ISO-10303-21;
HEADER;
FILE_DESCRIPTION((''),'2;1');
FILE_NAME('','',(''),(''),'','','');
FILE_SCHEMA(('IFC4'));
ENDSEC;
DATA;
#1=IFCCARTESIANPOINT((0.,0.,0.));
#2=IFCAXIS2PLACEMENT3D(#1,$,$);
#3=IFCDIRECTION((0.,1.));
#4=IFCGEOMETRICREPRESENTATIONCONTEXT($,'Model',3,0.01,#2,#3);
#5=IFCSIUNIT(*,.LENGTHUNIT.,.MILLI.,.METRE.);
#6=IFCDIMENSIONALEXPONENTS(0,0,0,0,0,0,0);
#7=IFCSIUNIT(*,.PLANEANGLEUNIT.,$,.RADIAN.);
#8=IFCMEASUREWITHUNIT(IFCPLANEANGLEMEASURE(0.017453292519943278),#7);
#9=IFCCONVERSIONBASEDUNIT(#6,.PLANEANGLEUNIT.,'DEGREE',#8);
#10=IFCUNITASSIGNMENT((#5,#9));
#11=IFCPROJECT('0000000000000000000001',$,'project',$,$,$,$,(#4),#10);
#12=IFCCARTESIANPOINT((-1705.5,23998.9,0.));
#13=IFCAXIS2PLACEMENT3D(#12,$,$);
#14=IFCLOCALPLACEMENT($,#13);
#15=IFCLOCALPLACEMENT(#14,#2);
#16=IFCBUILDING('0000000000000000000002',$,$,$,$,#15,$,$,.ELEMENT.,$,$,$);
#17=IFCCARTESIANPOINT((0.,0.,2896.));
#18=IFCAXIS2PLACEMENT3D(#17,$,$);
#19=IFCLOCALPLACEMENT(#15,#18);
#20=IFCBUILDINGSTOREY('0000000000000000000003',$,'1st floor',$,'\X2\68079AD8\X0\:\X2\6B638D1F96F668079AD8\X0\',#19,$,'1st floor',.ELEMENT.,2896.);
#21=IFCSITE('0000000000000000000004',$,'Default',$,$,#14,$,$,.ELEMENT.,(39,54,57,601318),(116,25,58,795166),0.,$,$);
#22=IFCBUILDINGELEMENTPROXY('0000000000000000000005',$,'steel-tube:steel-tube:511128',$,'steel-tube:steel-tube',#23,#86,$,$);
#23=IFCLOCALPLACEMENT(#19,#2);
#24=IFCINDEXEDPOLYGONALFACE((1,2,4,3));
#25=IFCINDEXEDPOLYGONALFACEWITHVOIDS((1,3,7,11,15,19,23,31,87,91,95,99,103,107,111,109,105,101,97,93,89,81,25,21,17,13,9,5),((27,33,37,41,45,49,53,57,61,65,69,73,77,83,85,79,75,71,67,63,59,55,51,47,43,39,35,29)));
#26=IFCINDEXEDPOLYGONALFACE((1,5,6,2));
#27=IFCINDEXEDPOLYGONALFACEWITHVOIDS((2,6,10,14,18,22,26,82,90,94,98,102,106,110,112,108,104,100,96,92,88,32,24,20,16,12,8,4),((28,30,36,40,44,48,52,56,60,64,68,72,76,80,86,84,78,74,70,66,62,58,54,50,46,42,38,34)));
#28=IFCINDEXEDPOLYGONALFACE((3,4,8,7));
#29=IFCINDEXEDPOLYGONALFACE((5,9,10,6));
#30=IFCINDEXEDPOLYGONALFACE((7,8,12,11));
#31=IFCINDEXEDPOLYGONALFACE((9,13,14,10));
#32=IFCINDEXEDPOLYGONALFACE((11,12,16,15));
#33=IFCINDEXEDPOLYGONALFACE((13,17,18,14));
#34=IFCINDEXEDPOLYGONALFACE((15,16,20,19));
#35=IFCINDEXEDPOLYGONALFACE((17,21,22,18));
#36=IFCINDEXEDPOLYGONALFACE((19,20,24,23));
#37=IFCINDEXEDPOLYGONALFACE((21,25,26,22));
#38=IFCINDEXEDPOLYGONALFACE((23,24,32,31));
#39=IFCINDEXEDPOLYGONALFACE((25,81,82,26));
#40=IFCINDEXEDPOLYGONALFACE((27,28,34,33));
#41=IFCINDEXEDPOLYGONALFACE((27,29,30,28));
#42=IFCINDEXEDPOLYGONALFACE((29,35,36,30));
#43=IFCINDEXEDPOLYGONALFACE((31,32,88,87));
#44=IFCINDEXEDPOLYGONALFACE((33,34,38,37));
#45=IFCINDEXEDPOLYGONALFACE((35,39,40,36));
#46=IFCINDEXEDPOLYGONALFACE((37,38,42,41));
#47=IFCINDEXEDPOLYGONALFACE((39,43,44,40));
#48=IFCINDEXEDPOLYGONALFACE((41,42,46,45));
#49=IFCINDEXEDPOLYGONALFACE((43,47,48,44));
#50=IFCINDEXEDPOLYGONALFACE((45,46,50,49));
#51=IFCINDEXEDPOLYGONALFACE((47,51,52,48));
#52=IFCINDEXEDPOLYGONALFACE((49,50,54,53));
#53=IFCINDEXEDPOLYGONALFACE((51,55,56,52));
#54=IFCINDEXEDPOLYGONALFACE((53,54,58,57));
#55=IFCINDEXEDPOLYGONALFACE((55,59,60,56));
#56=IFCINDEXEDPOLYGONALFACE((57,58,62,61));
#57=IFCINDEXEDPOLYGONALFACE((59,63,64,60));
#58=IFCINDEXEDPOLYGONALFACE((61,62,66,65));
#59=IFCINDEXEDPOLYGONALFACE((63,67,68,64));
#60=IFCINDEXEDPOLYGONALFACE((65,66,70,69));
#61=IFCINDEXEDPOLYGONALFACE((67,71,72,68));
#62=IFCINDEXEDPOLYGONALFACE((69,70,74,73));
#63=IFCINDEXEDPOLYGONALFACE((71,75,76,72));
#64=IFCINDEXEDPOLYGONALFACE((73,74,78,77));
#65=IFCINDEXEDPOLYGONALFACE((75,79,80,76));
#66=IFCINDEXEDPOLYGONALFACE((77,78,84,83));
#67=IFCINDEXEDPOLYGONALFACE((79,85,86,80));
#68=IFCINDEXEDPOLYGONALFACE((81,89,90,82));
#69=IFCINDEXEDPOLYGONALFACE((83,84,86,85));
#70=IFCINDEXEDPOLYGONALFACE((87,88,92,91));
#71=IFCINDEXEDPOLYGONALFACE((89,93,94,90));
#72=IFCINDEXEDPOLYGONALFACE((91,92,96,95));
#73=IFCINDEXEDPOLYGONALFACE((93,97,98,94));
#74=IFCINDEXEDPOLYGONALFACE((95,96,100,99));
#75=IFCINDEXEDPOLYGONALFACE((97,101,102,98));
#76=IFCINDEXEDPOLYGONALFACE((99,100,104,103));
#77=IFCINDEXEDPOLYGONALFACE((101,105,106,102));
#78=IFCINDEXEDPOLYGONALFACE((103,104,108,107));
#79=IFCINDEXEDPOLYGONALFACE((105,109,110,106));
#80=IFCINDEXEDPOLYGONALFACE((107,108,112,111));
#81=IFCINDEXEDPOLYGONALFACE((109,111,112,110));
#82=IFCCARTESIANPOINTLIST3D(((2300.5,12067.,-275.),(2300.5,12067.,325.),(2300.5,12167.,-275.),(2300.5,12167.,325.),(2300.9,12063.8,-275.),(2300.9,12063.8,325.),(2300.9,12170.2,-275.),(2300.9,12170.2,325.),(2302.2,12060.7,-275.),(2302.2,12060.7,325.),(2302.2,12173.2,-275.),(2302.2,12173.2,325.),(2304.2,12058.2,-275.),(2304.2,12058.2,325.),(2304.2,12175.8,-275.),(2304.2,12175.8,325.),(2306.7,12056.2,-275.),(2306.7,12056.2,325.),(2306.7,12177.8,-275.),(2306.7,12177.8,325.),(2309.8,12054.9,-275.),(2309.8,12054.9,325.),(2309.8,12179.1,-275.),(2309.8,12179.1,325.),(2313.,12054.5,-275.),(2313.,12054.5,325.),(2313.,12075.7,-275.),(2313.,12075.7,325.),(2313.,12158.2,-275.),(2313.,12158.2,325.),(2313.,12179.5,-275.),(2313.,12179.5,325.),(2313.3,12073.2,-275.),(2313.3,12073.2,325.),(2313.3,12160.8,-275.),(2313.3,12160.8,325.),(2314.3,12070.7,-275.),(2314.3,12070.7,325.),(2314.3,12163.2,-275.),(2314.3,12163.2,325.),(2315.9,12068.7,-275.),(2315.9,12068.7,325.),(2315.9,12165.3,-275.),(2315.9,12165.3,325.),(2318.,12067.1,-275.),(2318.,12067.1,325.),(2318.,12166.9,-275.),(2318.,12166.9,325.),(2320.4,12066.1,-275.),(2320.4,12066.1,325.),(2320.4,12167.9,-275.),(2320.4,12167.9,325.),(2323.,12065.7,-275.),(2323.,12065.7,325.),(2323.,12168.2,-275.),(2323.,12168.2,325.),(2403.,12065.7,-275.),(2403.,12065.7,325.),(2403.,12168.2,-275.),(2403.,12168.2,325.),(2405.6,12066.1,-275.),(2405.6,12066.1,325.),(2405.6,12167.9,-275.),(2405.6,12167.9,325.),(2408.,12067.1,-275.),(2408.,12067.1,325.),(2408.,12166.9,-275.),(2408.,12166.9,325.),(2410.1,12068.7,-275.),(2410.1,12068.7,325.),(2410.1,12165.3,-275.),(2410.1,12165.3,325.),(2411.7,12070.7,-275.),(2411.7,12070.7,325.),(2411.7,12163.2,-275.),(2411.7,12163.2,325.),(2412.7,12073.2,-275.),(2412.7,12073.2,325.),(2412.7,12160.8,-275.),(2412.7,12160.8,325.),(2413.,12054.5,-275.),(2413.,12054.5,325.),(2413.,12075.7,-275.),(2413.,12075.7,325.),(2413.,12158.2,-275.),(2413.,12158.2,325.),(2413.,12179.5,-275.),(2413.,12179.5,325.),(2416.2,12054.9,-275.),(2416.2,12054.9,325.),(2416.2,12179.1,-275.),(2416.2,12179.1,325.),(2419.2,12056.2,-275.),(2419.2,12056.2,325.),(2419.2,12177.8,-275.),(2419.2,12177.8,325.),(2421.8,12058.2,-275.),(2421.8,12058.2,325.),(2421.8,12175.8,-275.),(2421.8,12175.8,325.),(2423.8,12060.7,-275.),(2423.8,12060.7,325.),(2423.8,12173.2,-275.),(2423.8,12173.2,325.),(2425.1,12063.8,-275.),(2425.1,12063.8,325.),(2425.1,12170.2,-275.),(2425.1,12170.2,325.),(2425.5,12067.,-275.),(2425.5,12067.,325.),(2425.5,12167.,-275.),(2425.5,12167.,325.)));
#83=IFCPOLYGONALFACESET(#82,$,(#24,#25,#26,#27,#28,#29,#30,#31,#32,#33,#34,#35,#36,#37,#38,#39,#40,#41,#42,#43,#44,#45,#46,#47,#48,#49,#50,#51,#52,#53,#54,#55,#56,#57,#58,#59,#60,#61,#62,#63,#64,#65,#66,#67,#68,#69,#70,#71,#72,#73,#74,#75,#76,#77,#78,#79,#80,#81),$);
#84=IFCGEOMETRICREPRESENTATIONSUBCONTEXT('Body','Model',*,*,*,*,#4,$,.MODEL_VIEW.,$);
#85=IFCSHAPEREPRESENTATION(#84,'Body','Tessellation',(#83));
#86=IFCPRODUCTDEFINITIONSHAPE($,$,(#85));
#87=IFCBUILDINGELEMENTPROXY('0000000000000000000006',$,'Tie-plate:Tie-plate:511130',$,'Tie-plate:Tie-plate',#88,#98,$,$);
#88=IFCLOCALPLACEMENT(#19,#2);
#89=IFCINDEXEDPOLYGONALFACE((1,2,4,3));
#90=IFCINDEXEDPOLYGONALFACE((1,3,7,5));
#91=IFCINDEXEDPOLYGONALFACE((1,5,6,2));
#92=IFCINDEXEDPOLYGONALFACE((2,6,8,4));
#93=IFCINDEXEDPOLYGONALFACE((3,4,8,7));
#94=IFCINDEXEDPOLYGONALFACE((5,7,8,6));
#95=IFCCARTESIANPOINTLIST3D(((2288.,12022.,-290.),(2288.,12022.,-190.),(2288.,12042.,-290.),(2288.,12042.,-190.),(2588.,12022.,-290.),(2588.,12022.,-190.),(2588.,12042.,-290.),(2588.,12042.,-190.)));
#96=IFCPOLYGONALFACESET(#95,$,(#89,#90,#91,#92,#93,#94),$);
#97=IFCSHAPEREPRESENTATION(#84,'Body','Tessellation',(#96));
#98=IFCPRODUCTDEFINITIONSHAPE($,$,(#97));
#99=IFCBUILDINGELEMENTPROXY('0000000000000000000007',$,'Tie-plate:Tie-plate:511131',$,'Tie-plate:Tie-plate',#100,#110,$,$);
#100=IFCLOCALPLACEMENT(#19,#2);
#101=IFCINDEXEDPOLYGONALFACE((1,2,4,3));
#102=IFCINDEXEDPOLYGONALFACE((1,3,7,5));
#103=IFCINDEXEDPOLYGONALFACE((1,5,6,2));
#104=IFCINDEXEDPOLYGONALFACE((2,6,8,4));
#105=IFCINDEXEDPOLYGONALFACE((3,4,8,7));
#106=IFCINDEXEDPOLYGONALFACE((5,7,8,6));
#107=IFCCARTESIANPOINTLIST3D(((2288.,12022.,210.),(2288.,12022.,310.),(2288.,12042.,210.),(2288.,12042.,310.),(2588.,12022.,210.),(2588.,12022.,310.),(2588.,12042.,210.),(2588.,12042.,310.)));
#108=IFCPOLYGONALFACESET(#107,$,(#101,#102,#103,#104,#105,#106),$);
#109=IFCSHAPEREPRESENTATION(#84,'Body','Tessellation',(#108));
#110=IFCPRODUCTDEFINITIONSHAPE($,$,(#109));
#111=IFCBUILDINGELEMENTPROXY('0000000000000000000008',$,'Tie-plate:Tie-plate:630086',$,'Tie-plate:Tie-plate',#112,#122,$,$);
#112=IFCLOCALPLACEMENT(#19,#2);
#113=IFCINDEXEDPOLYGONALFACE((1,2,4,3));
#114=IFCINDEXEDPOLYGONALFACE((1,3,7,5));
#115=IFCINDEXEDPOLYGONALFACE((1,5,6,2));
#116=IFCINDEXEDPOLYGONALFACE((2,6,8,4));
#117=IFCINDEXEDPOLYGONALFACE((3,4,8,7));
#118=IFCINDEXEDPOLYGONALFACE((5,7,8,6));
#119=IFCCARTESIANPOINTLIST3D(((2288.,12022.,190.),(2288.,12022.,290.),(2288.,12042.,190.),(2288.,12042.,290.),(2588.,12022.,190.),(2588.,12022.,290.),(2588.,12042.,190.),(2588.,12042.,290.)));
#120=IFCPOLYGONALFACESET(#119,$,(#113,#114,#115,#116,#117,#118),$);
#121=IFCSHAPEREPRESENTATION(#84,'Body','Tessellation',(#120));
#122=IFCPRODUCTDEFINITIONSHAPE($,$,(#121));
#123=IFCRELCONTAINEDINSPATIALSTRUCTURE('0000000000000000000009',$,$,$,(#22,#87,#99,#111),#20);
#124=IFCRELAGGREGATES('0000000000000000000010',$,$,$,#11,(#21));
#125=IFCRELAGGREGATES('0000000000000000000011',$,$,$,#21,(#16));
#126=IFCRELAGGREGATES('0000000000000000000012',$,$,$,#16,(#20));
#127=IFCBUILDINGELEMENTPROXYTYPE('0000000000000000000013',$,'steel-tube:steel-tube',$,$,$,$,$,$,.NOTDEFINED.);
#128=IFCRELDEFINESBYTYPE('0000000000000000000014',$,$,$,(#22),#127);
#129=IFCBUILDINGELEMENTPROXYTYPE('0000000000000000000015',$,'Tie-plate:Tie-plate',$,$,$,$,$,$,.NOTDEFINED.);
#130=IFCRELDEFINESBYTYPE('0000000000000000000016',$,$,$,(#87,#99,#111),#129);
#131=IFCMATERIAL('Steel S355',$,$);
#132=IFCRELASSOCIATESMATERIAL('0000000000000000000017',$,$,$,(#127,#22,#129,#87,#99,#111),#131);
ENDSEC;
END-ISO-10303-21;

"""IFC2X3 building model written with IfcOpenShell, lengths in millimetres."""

from ifc_helpers import new_model, entity, si_unit, converted_unit, direction, frame, frame_2d, origin, place, context, subcontext, project, spatial, polyline, circle_curve, parameter, trimmed, segment, composite_curve, rectangle, outline, extrude, source, transform, mapped, material, type_object, type_shapes, element, save


model = new_model("IFC2X3")

# Units and contexts
model_context = context("Model", 3, precision=0.01, world=origin(), true_north=direction((0.0, 1.0)))
body_context = subcontext(model_context, "Body", "Model", "MODEL_VIEW")
ifc_project = project(units=[si_unit("LENGTHUNIT", "METRE", prefix="MILLI"), converted_unit("PLANEANGLEUNIT", "DEGREE", entity("IfcPlaneAngleMeasure", 0.017453292519943278), si_unit("PLANEANGLEUNIT", "RADIAN"), dimensions=[0, 0, 0, 0, 0, 0, 0])], contexts=[model_context])

# Site, building, storey
site_placement = place(None, frame((-1705.5, 23998.9, 0.0)))
site = spatial("IfcSite", under=ifc_project, at=site_placement, Name="Default", CompositionType="ELEMENT", RefLatitude=(39, 54, 57, 601318), RefLongitude=(116, 25, 58, 795166), RefElevation=0.0)
building_placement = place(site_placement, origin())
building = spatial("IfcBuilding", under=site, at=building_placement, CompositionType="ELEMENT")
storey_placement = place(building_placement, frame((0.0, 0.0, 2896.0)))
storey = spatial("IfcBuildingStorey", under=building, at=storey_placement, Name="1st floor", ObjectType="标高:正负零标高", LongName="1st floor", CompositionType="ELEMENT", Elevation=2896.0)

# Shared definitions
ifc_material_1 = material(Name="Steel S355")

# Building element proxies
building_element_proxy_type_1 = type_object("IfcBuildingElementProxyType", Name="steel-tube:steel-tube", PredefinedType="NOTDEFINED", material=ifc_material_1)
shared_shape_1 = source(origin(), body_context, "Body", "SweptSolid", [
    extrude(outline(composite_curve([segment(trimmed(circle_curve(frame_2d((50.0, -50.0), x_axis=(1.0, 0.0)), 12.5), [parameter(270.0)], [parameter(0.0)], True, "PARAMETER"), True, "CONTINUOUS"), segment(polyline([(62.5, -50.0), (62.5, 50.0)]), True, "CONTINUOUS"), segment(trimmed(circle_curve(frame_2d((50.0, 50.0), x_axis=(1.0, 0.0)), 12.5), [parameter(0.0)], [parameter(90.0)], True, "PARAMETER"), True, "CONTINUOUS"), segment(polyline([(50.0, 62.5), (-50.0, 62.5)]), True, "CONTINUOUS"), segment(trimmed(circle_curve(frame_2d((-50.0, 50.0), x_axis=(1.0, 0.0)), 12.5), [parameter(90.0)], [parameter(180.0)], True, "PARAMETER"), True, "CONTINUOUS"), segment(polyline([(-62.5, 50.0), (-62.5, -50.0)]), True, "CONTINUOUS"), segment(trimmed(circle_curve(frame_2d((-50.0, -50.0), x_axis=(1.0, 0.0)), 12.5), [parameter(180.0)], [parameter(270.0)], True, "PARAMETER"), True, "CONTINUOUS"), segment(polyline([(-50.0, -62.5), (50.0, -62.5)]), True, "CONTINUOUS")], self_intersect=False), holes=[composite_curve([segment(trimmed(circle_curve(frame_2d((-41.2, 40.0), x_axis=(1.0, 0.0)), 10.0), [parameter(90.0)], [parameter(180.0)], True, "PARAMETER"), False, "CONTINUOUS"), segment(polyline([(-41.3, 50.0), (41.2, 50.0)]), True, "CONTINUOUS"), segment(trimmed(circle_curve(frame_2d((41.2, 40.0), x_axis=(1.0, 0.0)), 10.0), [parameter(0.0)], [parameter(90.0)], True, "PARAMETER"), False, "CONTINUOUS"), segment(polyline([(51.2, 40.0), (51.2, -40.0)]), True, "CONTINUOUS"), segment(trimmed(circle_curve(frame_2d((41.2, -40.0), x_axis=(1.0, 0.0)), 10.0), [parameter(270.0)], [parameter(360.0)], True, "PARAMETER"), False, "CONTINUOUS"), segment(polyline([(41.2, -50.0), (-41.3, -50.0)]), True, "CONTINUOUS"), segment(trimmed(circle_curve(frame_2d((-41.3, -40.0), x_axis=(1.0, 0.0)), 10.0), [parameter(180.0)], [parameter(270.0)], True, "PARAMETER"), False, "CONTINUOUS"), segment(polyline([(-51.3, -40.0), (-51.3, 40.0)]), True, "CONTINUOUS")], self_intersect=False)]), frame((62.5, 62.5, -175.0)), (0.0, 0.0, 1.0), 600.0),
])
type_shapes(building_element_proxy_type_1, [shared_shape_1])
for number, where, z_axis, x_axis, name in (
    (1, (2300.5, 12179.5, -100.0), (0.0, 0.0, 1.0), (0.0, -1.0, 0.0), "steel-tube:steel-tube:511128"),
):
    element("IfcBuildingElementProxy", number, at=place(storey_placement, frame(where, z_axis=z_axis, x_axis=x_axis)), inside=storey, type_object=building_element_proxy_type_1, material=ifc_material_1, Name=name, ObjectType="steel-tube:steel-tube", context=body_context, shape_type="MappedRepresentation", body=[
        mapped(shared_shape_1, transform((0.0, 0.0, 0.0), scale=1.0)),
    ])
building_element_proxy_type_2 = type_object("IfcBuildingElementProxyType", Name="Tie-plate:Tie-plate", PredefinedType="NOTDEFINED", material=ifc_material_1)
shared_shape_2 = source(origin(), body_context, "Body", "SweptSolid", [
    extrude(rectangle(XDim=300.0, YDim=20.0, at=frame_2d((0.0, 0.0), x_axis=(1.0, 0.0))), frame((150.0, -10.0, 0.0), z_axis=(0.0, 0.0, 1.0), x_axis=(-1.0, 0.0, 0.0)), (0.0, 0.0, 1.0), 100.0),
])
type_shapes(building_element_proxy_type_2, [shared_shape_2])
for number, where, name in (
    (2, (2288.0, 12042.0, -290.0), "Tie-plate:Tie-plate:511130"),
    (3, (2288.0, 12042.0, 210.0), "Tie-plate:Tie-plate:511131"),
    (4, (2288.0, 12042.0, 190.0), "Tie-plate:Tie-plate:630086"),
):
    element("IfcBuildingElementProxy", number, at=place(storey_placement, frame(where)), inside=storey, type_object=building_element_proxy_type_2, material=ifc_material_1, Name=name, ObjectType="Tie-plate:Tie-plate", context=body_context, shape_type="MappedRepresentation", body=[
        mapped(shared_shape_2, transform((0.0, 0.0, 0.0), scale=1.0)),
    ])

save(model, "model.ifc")
